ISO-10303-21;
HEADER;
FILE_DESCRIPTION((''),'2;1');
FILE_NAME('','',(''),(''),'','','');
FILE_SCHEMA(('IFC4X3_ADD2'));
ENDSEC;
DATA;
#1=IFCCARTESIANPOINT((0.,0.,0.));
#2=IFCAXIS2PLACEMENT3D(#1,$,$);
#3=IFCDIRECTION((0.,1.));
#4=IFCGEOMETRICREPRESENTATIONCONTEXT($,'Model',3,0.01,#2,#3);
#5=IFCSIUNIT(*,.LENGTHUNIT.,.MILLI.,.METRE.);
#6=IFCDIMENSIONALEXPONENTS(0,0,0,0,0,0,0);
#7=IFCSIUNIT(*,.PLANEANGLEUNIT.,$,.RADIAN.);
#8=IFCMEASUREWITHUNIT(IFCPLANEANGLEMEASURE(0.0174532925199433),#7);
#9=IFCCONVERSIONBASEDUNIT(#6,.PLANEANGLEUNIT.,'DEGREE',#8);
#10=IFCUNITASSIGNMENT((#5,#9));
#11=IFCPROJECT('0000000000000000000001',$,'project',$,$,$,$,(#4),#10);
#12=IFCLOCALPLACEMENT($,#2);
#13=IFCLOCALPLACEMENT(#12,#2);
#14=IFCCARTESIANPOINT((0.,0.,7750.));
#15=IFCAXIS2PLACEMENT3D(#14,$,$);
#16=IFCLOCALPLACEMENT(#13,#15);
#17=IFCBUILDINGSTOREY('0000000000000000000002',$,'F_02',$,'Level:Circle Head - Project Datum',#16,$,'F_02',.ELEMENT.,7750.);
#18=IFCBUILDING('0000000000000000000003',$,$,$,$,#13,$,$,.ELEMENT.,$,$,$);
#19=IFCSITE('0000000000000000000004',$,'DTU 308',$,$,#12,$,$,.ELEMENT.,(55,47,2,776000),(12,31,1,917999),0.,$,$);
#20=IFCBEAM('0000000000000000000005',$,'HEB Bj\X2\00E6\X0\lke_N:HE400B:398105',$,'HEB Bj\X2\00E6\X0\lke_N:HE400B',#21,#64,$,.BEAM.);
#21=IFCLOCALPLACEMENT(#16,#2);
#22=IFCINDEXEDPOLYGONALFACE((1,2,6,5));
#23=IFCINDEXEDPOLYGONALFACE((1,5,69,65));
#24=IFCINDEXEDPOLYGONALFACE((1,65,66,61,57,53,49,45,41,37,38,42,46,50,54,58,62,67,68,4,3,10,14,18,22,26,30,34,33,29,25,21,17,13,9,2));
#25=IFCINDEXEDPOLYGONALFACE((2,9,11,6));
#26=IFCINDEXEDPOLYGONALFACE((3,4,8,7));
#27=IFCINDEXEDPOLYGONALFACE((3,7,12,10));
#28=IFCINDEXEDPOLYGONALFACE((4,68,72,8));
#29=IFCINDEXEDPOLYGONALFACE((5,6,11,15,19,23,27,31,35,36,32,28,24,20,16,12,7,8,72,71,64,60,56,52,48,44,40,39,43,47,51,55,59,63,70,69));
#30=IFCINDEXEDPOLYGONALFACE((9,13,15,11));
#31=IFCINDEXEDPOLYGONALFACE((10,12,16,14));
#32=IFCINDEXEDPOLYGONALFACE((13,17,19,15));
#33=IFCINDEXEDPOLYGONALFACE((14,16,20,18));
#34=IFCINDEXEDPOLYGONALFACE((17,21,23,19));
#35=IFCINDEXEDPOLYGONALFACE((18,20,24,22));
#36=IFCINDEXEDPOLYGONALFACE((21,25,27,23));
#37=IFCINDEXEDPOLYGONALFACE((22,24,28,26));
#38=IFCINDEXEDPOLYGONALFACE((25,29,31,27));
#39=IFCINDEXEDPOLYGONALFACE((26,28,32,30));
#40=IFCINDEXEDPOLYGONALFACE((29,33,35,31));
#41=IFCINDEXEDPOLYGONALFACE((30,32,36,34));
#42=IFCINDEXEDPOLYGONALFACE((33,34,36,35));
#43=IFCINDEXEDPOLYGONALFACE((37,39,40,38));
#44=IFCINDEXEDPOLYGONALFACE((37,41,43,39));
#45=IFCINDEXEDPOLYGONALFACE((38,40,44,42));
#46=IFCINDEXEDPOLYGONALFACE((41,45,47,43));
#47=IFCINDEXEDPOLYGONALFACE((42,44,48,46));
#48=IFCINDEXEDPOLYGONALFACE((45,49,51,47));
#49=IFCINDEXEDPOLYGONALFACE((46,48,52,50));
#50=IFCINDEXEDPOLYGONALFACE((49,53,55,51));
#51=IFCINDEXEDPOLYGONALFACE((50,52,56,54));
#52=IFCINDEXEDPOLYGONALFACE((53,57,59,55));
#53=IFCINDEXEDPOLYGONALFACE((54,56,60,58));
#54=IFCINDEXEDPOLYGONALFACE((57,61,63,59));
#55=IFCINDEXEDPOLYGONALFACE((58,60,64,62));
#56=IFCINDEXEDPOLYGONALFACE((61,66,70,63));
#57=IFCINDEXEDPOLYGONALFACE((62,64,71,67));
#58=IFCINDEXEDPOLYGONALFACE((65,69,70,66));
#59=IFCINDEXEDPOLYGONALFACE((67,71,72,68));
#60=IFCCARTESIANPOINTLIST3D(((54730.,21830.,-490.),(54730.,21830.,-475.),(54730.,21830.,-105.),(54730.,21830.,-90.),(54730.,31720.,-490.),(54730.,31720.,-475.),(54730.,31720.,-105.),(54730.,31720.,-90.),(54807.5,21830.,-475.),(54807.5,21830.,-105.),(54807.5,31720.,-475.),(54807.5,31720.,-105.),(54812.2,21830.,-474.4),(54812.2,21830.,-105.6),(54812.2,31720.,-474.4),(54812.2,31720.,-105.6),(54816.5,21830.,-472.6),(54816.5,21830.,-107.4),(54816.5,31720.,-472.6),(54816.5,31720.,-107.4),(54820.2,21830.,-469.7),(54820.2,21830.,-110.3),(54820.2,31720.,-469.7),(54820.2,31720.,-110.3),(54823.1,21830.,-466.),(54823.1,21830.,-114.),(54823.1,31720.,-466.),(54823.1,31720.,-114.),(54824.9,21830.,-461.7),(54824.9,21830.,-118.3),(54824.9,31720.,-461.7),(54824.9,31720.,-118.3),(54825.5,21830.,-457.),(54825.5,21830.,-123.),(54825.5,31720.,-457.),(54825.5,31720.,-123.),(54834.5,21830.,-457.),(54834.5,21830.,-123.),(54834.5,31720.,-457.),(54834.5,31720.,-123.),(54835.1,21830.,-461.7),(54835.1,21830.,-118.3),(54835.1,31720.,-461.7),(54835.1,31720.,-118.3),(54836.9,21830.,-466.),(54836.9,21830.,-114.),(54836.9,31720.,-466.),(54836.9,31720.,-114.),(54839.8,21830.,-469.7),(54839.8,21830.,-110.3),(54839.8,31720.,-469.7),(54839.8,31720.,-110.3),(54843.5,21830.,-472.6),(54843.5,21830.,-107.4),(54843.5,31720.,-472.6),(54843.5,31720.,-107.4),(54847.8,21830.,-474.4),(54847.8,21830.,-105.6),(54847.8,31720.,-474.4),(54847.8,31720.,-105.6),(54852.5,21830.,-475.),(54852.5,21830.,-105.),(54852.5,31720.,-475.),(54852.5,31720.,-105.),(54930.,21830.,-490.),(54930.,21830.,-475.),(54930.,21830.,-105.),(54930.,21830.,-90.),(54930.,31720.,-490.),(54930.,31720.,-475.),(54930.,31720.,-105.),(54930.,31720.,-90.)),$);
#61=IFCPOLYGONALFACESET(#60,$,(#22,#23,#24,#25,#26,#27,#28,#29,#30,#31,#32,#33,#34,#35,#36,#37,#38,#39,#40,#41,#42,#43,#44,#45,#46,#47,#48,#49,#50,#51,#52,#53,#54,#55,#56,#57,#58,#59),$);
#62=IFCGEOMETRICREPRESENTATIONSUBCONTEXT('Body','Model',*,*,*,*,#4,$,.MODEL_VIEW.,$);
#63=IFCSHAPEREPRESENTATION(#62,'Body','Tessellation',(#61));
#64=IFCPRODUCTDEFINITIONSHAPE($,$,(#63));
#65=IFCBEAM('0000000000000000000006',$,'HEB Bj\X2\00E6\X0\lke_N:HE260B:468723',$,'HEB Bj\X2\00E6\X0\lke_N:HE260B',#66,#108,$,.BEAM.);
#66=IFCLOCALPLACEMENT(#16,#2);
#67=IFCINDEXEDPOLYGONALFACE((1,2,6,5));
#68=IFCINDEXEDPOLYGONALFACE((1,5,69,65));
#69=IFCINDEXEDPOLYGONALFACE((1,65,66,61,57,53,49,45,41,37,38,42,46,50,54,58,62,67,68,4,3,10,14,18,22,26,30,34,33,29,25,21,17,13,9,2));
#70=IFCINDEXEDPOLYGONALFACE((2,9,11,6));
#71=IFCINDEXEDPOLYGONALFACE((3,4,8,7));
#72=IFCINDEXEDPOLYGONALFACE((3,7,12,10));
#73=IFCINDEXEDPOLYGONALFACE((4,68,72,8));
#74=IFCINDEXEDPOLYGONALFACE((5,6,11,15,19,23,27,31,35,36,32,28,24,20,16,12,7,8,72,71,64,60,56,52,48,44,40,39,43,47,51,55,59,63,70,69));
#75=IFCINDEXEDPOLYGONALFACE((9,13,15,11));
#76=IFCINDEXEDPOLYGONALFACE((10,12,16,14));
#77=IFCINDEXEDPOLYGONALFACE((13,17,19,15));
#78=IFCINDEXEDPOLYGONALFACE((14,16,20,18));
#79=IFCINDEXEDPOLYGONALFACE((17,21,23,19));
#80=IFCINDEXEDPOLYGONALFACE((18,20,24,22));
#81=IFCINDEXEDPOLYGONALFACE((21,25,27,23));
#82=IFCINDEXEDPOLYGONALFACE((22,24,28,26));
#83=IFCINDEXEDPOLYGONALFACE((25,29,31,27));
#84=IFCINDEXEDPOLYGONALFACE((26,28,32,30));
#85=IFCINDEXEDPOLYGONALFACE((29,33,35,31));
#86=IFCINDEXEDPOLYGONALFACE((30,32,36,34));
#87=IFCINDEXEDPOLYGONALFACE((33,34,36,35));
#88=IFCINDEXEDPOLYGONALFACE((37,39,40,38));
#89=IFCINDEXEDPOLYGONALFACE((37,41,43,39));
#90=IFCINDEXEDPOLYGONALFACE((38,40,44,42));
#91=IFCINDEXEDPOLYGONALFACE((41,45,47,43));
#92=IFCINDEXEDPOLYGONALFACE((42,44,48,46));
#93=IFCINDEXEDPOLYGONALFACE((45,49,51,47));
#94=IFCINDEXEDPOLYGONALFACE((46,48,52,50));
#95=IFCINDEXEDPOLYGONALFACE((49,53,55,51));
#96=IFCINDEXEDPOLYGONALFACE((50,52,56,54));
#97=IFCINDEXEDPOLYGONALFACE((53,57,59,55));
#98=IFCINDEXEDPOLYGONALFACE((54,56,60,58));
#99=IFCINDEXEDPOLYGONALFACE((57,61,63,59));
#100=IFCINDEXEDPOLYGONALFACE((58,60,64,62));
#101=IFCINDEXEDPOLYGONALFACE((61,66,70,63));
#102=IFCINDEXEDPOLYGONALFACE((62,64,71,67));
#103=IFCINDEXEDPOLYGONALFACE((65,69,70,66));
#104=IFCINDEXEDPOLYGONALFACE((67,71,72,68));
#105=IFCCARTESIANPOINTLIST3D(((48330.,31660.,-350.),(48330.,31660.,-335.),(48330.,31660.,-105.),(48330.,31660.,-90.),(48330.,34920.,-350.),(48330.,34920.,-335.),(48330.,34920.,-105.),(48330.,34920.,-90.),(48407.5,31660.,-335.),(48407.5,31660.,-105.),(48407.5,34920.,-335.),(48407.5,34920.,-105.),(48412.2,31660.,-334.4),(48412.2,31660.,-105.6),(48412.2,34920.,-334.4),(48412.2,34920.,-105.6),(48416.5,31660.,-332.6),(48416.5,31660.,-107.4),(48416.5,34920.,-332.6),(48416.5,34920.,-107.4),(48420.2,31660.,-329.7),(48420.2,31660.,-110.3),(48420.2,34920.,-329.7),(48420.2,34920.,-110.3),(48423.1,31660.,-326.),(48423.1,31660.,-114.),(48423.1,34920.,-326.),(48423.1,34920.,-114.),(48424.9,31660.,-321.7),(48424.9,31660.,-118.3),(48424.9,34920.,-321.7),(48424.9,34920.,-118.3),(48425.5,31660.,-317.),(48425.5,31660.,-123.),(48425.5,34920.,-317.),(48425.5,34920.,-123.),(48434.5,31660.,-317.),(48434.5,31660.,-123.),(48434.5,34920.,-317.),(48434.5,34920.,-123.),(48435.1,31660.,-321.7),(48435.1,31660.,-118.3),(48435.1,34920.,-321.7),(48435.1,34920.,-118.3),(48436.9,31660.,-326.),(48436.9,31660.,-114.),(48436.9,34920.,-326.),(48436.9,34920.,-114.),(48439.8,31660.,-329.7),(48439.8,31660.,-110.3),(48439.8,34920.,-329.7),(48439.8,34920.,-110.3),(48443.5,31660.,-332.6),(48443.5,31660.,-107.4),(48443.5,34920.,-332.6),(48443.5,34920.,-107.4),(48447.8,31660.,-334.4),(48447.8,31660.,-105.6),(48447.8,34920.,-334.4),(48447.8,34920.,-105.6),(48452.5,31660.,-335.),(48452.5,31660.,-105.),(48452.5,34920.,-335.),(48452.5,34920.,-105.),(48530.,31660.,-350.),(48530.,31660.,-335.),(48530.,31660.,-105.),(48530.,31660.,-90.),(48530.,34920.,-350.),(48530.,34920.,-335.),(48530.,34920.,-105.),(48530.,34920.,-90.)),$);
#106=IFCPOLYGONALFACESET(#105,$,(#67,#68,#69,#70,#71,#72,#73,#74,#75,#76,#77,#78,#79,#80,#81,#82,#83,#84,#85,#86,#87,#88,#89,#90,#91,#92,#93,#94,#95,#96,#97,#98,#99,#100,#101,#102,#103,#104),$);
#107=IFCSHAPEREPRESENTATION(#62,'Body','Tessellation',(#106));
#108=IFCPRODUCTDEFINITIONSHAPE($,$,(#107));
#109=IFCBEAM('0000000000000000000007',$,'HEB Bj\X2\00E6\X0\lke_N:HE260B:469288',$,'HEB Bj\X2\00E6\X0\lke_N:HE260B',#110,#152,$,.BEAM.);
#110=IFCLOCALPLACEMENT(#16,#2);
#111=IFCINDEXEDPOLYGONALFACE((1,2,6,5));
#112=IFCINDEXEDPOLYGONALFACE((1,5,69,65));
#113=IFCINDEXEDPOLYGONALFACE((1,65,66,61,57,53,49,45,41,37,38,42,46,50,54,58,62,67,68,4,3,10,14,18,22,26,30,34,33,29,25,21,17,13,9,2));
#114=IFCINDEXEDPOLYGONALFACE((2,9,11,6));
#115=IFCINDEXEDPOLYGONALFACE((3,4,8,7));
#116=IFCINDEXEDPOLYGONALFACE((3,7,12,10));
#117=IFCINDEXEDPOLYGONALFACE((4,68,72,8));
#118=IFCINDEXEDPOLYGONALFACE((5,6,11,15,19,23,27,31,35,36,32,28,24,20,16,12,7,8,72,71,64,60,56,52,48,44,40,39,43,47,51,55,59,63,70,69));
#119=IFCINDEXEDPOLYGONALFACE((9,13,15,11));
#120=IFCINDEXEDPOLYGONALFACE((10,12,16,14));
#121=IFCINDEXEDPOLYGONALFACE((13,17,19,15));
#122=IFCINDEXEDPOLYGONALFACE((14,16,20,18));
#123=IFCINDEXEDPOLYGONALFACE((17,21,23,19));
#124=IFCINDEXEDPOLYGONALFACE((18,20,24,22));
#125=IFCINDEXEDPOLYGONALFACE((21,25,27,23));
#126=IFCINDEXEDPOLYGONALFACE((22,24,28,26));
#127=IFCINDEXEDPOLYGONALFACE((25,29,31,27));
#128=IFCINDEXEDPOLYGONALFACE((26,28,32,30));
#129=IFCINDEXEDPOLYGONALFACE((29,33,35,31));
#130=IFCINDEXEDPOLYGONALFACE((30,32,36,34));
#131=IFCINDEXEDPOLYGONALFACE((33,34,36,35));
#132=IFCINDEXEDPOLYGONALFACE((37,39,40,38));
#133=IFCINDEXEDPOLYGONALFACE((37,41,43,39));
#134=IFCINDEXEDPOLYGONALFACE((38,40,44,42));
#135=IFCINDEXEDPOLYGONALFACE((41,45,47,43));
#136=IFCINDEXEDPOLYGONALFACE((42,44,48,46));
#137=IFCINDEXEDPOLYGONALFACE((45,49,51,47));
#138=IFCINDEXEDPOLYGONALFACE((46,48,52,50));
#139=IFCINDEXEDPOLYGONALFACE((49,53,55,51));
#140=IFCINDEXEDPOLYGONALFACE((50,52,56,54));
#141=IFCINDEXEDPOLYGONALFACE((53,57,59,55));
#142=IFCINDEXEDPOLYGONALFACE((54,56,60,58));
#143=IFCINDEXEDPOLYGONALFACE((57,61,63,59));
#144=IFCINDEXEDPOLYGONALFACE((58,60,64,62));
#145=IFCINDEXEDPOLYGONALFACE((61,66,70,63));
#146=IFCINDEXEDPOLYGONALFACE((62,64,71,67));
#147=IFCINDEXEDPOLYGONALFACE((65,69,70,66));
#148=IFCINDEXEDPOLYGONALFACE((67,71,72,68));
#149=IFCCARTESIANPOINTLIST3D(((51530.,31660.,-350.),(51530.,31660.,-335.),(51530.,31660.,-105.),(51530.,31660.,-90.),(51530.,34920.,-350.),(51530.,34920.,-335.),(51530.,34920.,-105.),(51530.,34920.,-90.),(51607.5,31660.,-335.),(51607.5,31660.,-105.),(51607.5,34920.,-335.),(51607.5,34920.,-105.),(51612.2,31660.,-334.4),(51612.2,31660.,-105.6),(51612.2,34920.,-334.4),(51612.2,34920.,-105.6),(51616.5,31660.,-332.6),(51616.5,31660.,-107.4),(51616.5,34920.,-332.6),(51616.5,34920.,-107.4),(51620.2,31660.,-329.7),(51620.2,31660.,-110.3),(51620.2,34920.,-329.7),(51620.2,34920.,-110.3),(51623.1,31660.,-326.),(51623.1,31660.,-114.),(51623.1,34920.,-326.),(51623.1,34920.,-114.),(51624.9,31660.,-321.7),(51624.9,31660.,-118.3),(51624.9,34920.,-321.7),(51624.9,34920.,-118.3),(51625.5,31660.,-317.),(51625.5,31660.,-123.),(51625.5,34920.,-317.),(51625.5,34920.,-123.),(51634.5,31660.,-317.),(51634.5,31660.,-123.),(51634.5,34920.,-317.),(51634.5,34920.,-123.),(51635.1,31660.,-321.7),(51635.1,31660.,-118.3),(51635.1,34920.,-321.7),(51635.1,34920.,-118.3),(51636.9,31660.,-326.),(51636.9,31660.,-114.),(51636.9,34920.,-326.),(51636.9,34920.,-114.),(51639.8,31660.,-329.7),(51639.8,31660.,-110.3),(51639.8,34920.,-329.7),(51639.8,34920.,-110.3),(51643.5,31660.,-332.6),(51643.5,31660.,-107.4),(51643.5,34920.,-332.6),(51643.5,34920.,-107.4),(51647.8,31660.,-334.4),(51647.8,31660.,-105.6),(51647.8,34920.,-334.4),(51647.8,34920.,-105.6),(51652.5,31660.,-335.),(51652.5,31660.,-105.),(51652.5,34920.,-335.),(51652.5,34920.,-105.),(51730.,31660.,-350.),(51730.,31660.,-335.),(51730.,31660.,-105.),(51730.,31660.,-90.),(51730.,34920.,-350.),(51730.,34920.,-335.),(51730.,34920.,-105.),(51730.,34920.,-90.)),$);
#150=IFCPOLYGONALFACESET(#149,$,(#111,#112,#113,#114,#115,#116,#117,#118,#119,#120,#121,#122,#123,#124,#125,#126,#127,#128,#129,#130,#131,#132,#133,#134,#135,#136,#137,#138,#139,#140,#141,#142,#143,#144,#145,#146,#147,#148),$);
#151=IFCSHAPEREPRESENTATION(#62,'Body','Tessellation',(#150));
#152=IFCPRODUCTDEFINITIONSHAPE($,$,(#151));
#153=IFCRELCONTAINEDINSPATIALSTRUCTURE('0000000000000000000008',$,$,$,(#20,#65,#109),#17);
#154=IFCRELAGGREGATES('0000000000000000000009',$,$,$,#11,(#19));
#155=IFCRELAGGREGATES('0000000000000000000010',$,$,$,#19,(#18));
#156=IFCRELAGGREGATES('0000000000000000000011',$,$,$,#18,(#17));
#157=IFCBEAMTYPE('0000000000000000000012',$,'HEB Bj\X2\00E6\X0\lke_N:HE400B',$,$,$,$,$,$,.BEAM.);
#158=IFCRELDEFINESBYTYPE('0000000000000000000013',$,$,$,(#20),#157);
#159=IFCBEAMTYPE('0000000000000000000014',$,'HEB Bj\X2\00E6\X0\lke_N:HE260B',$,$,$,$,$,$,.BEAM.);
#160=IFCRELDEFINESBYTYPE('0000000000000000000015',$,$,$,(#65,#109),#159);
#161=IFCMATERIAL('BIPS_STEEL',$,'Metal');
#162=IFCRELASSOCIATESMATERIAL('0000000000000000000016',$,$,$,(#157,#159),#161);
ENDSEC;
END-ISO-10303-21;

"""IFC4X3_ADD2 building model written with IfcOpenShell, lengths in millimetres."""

from ifc_helpers import new_model, entity, si_unit, converted_unit, direction, frame, frame_2d, origin, place, context, subcontext, project, spatial, polyline, circle_curve, parameter, trimmed, segment, composite_curve, i_section, outline, extrude, source, transform, mapped, material, material_profile, profile_set, type_object, element, save


model = new_model("IFC4X3_ADD2")

# Units and contexts
model_context = context("Model", 3, precision=0.01, world=origin(), true_north=direction((0.0, 1.0)))
body_context = subcontext(model_context, "Body", "Model", "MODEL_VIEW")
ifc_project = project(units=[si_unit("LENGTHUNIT", "METRE", prefix="MILLI"), converted_unit("PLANEANGLEUNIT", "DEGREE", entity("IfcPlaneAngleMeasure", 0.0174532925199433), si_unit("PLANEANGLEUNIT", "RADIAN"), dimensions=[0, 0, 0, 0, 0, 0, 0])], contexts=[model_context])

# Site, building, storey
site_placement = place(None, origin())
site = spatial("IfcSite", under=ifc_project, at=site_placement, Name="DTU 308", CompositionType="ELEMENT", RefLatitude=(55, 47, 2, 776000), RefLongitude=(12, 31, 1, 917999), RefElevation=0.0)
building_placement = place(site_placement, origin())
building = spatial("IfcBuilding", under=site, at=building_placement, CompositionType="ELEMENT")
storey_placement = place(building_placement, frame((0.0, 0.0, 7750.0)))
storey = spatial("IfcBuildingStorey", under=building, at=storey_placement, Name="F_02", ObjectType="Level:Circle Head - Project Datum", LongName="F_02", CompositionType="ELEMENT", Elevation=7750.0)

# Shared definitions
ifc_material = material(Name="BIPS_STEEL", Category="Metal")

# Beams
ifc_material_profile_1 = material_profile(ifc_material, outline(composite_curve([segment(polyline([(-100.0, -185.0), (-100.0, -200.0)]), True, "CONTINUOUS"), segment(polyline([(-100.0, -200.0), (100.0, -200.0)]), True, "CONTINUOUS"), segment(polyline([(100.0, -200.0), (100.0, -185.0)]), True, "CONTINUOUS"), segment(polyline([(100.0, -185.0), (22.5, -185.0)]), True, "CONTINUOUS"), segment(trimmed(circle_curve(frame_2d((22.5, -167.0), x_axis=(1.0, 0.0)), 18.0), [parameter(180.0)], [parameter(270.0)], True, "PARAMETER"), False, "CONTINUOUS"), segment(polyline([(4.5, -167.0), (4.5, 167.0)]), True, "CONTINUOUS"), segment(trimmed(circle_curve(frame_2d((22.5, 167.0), x_axis=(1.0, 0.0)), 18.0), [parameter(90.0)], [parameter(180.0)], True, "PARAMETER"), False, "CONTINUOUS"), segment(polyline([(22.5, 185.0), (100.0, 185.0)]), True, "CONTINUOUS"), segment(polyline([(100.0, 185.0), (100.0, 200.0)]), True, "CONTINUOUS"), segment(polyline([(100.0, 200.0), (-100.0, 200.0)]), True, "CONTINUOUS"), segment(polyline([(-100.0, 200.0), (-100.0, 185.0)]), True, "CONTINUOUS"), segment(polyline([(-100.0, 185.0), (-22.5, 185.0)]), True, "CONTINUOUS"), segment(trimmed(circle_curve(frame_2d((-22.5, 167.0), x_axis=(1.0, 0.0)), 18.0), [parameter(360.0)], [parameter(90.0)], True, "PARAMETER"), False, "CONTINUOUS"), segment(polyline([(-4.5, 167.0), (-4.5, -167.0)]), True, "CONTINUOUS"), segment(trimmed(circle_curve(frame_2d((-22.5, -167.0), x_axis=(1.0, 0.0)), 18.0), [parameter(270.0)], [parameter(360.0)], True, "PARAMETER"), False, "CONTINUOUS"), segment(polyline([(-22.5, -185.0), (-100.0, -185.0)]), True, "CONTINUOUS")], self_intersect=False)), Name="HE400B")
ifc_profile_set_1 = profile_set([ifc_material_profile_1], Name="HE400B")
beam_type_1 = type_object("IfcBeamType", Name="HEB Bjælke_N:HE400B", PredefinedType="BEAM", material=ifc_profile_set_1)
ifc_material_profile_2 = material_profile(ifc_material, i_section(OverallWidth=200.0, OverallDepth=260.0, WebThickness=9.0, FlangeThickness=15.0, FilletRadius=18.0, at=frame_2d((0.0, 0.0), x_axis=(1.0, 0.0))), Name="HE260B")
ifc_profile_set_2 = profile_set([ifc_material_profile_2], Name="HE260B")
beam_type_2 = type_object("IfcBeamType", Name="HEB Bjælke_N:HE260B", PredefinedType="BEAM", material=ifc_profile_set_2)
shared_shape_1 = source(origin(), body_context, "Body", "SweptSolid", [
    extrude(outline(composite_curve([segment(polyline([(-100.0, -185.0), (-100.0, -200.0)]), True, "CONTINUOUS"), segment(polyline([(-100.0, -200.0), (100.0, -200.0)]), True, "CONTINUOUS"), segment(polyline([(100.0, -200.0), (100.0, -185.0)]), True, "CONTINUOUS"), segment(polyline([(100.0, -185.0), (22.5, -185.0)]), True, "CONTINUOUS"), segment(trimmed(circle_curve(frame_2d((22.5, -167.0), x_axis=(1.0, 0.0)), 18.0), [parameter(180.0)], [parameter(270.0)], True, "PARAMETER"), False, "CONTINUOUS"), segment(polyline([(4.5, -167.0), (4.5, 167.0)]), True, "CONTINUOUS"), segment(trimmed(circle_curve(frame_2d((22.5, 167.0), x_axis=(1.0, 0.0)), 18.0), [parameter(90.0)], [parameter(180.0)], True, "PARAMETER"), False, "CONTINUOUS"), segment(polyline([(22.5, 185.0), (100.0, 185.0)]), True, "CONTINUOUS"), segment(polyline([(100.0, 185.0), (100.0, 200.0)]), True, "CONTINUOUS"), segment(polyline([(100.0, 200.0), (-100.0, 200.0)]), True, "CONTINUOUS"), segment(polyline([(-100.0, 200.0), (-100.0, 185.0)]), True, "CONTINUOUS"), segment(polyline([(-100.0, 185.0), (-22.5, 185.0)]), True, "CONTINUOUS"), segment(trimmed(circle_curve(frame_2d((-22.5, 167.0), x_axis=(1.0, 0.0)), 18.0), [parameter(360.0)], [parameter(90.0)], True, "PARAMETER"), False, "CONTINUOUS"), segment(polyline([(-4.5, 167.0), (-4.5, -167.0)]), True, "CONTINUOUS"), segment(trimmed(circle_curve(frame_2d((-22.5, -167.0), x_axis=(1.0, 0.0)), 18.0), [parameter(270.0)], [parameter(360.0)], True, "PARAMETER"), False, "CONTINUOUS"), segment(polyline([(-22.5, -185.0), (-100.0, -185.0)]), True, "CONTINUOUS")], self_intersect=False)), frame((-6450.0, 0.0, 0.0), z_axis=(-1.0, 0.0, 0.0), x_axis=(0.0, -1.0, 0.0)), (0.0, 0.0, -1.0), 9890.0),
])
beam_1_placement = place(storey_placement, frame((54830.0, 28280.0, -290.0), z_axis=(0.0, 0.0, 1.0), x_axis=(0.0, 1.0, 0.0)))
element("IfcBeam", 1, at=beam_1_placement, inside=storey, type_object=beam_type_1, Name="HEB Bjælke_N:HE400B:398105", ObjectType="HEB Bjælke_N:HE400B", PredefinedType="BEAM", context=body_context, shape_type="MappedRepresentation", body=[
    mapped(shared_shape_1, transform((0.0, 0.0, 0.0), scale=1.0)),
])
shared_shape_2 = source(origin(), body_context, "Body", "SweptSolid", [
    extrude(outline(composite_curve([segment(polyline([(-100.0, -115.0), (-100.0, -130.0)]), True, "CONTINUOUS"), segment(polyline([(-100.0, -130.0), (100.0, -130.0)]), True, "CONTINUOUS"), segment(polyline([(100.0, -130.0), (100.0, -115.0)]), True, "CONTINUOUS"), segment(polyline([(100.0, -115.0), (22.5, -115.0)]), True, "CONTINUOUS"), segment(trimmed(circle_curve(frame_2d((22.5, -97.0), x_axis=(1.0, 0.0)), 18.0), [parameter(180.0)], [parameter(270.0)], True, "PARAMETER"), False, "CONTINUOUS"), segment(polyline([(4.5, -97.0), (4.5, 97.0)]), True, "CONTINUOUS"), segment(trimmed(circle_curve(frame_2d((22.5, 97.0), x_axis=(1.0, 0.0)), 18.0), [parameter(90.0)], [parameter(180.0)], True, "PARAMETER"), False, "CONTINUOUS"), segment(polyline([(22.5, 115.0), (100.0, 115.0)]), True, "CONTINUOUS"), segment(polyline([(100.0, 115.0), (100.0, 130.0)]), True, "CONTINUOUS"), segment(polyline([(100.0, 130.0), (-100.0, 130.0)]), True, "CONTINUOUS"), segment(polyline([(-100.0, 130.0), (-100.0, 115.0)]), True, "CONTINUOUS"), segment(polyline([(-100.0, 115.0), (-22.5, 115.0)]), True, "CONTINUOUS"), segment(trimmed(circle_curve(frame_2d((-22.5, 97.0), x_axis=(1.0, 0.0)), 18.0), [parameter(360.0)], [parameter(90.0)], True, "PARAMETER"), False, "CONTINUOUS"), segment(polyline([(-4.5, 97.0), (-4.5, -97.0)]), True, "CONTINUOUS"), segment(trimmed(circle_curve(frame_2d((-22.5, -97.0), x_axis=(1.0, 0.0)), 18.0), [parameter(270.0)], [parameter(360.0)], True, "PARAMETER"), False, "CONTINUOUS"), segment(polyline([(-22.5, -115.0), (-100.0, -115.0)]), True, "CONTINUOUS")], self_intersect=False)), frame((-1720.0, 0.0, 0.0), z_axis=(-1.0, 0.0, 0.0), x_axis=(0.0, -1.0, 0.0)), (0.0, 0.0, -1.0), 3260.0),
])
for number, where, z_axis, x_axis, name in (
    (2, (48430.0, 33200.0, -220.0), (0.0, 0.0, 1.0), (0.0, -1.0, 0.0), "HEB Bjælke_N:HE260B:468723"),
    (3, (51630.0, 33200.0, -220.0), (0.0, 0.0, 1.0), (0.0, -1.0, 0.0), "HEB Bjælke_N:HE260B:469288"),
):
    element("IfcBeam", number, at=place(storey_placement, frame(where, z_axis=z_axis, x_axis=x_axis)), inside=storey, type_object=beam_type_2, Name=name, ObjectType="HEB Bjælke_N:HE260B", PredefinedType="BEAM", context=body_context, shape_type="MappedRepresentation", body=[
        mapped(shared_shape_2, transform((0.0, 0.0, 0.0), scale=1.0)),
    ])

save(model, "model.ifc")
